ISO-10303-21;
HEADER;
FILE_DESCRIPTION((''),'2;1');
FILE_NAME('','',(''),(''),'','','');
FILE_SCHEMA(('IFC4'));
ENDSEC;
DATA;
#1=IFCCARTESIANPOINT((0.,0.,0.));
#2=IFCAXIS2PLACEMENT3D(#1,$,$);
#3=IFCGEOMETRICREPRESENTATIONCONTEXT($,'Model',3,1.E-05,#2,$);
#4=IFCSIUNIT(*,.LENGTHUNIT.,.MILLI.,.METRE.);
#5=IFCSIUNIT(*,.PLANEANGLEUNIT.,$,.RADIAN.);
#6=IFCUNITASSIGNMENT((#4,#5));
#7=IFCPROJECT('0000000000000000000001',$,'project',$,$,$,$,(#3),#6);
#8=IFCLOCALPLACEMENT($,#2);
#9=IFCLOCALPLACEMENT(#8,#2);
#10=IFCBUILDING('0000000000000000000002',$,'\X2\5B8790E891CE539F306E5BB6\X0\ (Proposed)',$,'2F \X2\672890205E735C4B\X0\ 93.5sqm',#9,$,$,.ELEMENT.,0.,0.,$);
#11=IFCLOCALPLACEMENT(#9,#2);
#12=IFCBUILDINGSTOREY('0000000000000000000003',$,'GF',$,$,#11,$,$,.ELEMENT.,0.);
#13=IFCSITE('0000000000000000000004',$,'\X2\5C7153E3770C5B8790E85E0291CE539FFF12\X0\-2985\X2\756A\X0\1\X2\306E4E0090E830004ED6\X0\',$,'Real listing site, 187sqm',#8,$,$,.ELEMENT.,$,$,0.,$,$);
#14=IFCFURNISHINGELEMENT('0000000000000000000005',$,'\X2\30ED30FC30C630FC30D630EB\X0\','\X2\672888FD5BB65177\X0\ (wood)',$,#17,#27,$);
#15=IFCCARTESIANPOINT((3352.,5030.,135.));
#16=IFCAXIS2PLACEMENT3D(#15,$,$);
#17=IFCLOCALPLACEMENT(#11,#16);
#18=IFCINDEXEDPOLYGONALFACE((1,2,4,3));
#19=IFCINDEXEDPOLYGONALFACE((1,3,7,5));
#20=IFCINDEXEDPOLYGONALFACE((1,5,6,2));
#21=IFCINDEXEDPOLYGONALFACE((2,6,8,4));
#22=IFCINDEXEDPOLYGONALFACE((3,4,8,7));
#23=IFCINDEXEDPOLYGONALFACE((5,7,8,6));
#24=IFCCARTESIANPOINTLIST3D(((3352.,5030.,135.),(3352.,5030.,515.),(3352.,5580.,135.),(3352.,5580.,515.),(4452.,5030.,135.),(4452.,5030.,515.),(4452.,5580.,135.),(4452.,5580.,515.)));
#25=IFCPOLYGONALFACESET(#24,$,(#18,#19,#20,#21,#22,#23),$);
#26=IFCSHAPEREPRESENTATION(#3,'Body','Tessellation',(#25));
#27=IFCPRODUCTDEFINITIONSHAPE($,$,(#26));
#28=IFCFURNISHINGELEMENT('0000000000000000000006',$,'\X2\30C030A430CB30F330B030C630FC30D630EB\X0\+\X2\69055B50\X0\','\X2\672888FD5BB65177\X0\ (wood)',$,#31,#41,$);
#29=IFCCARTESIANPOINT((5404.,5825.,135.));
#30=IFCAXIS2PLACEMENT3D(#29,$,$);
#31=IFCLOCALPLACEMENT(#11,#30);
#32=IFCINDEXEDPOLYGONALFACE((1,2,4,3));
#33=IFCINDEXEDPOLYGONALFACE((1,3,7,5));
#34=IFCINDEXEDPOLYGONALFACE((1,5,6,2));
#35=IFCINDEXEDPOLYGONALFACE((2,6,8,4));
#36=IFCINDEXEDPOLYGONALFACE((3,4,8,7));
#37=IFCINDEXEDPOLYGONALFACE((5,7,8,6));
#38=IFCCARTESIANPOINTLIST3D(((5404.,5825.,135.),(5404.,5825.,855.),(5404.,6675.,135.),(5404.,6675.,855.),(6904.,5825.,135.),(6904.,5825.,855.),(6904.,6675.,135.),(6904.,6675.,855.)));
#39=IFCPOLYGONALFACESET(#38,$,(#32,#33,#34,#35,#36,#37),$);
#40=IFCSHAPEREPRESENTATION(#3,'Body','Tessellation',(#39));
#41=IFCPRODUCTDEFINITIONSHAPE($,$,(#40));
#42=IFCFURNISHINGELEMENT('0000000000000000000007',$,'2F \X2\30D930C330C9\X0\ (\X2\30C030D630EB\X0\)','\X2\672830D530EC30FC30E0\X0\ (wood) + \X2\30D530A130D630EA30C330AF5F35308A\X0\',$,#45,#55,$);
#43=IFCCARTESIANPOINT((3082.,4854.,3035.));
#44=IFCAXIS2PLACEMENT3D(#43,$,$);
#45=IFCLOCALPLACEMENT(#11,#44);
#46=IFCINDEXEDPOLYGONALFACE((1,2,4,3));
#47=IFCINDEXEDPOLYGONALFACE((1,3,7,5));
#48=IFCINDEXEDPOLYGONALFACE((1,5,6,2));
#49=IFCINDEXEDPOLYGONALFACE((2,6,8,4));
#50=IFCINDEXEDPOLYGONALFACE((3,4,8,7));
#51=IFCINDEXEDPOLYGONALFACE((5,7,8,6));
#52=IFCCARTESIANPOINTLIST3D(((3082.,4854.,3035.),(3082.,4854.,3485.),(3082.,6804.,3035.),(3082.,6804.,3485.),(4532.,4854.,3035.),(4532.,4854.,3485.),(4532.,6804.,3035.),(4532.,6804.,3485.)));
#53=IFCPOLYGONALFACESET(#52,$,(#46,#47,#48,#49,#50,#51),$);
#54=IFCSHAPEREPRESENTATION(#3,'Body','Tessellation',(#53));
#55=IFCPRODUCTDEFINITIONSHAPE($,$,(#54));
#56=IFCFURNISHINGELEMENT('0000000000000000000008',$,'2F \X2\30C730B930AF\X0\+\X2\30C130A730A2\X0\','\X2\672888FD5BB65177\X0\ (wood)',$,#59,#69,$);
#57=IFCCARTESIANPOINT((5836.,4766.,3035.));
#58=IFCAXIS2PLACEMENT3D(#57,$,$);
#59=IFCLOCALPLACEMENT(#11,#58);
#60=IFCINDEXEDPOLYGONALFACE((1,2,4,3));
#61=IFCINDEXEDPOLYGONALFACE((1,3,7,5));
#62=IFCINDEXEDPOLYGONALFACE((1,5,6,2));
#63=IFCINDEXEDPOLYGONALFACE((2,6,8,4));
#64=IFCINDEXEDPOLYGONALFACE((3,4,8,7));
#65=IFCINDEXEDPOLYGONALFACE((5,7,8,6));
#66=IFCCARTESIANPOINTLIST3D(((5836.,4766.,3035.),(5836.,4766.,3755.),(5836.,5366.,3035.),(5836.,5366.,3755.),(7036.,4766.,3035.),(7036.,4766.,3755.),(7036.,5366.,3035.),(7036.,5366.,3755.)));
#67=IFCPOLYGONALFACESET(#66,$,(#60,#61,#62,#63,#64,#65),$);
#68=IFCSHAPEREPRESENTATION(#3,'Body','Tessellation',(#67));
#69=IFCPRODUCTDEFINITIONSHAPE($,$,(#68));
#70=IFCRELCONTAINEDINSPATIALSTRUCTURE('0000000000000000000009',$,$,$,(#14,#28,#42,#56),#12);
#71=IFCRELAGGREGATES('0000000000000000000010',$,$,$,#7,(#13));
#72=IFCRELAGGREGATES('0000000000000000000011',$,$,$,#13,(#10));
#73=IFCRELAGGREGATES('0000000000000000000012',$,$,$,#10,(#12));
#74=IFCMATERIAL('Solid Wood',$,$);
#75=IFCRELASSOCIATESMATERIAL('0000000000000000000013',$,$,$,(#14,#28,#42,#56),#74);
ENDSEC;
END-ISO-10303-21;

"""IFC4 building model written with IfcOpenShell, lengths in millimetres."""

from ifc_helpers import new_model, si_unit, frame, frame_2d, origin, place, context, project, spatial, rectangle, extrude, material, element, save


model = new_model("IFC4")

# Units and contexts
model_context = context("Model", 3, precision=1e-05, world=origin())
ifc_project = project(units=[si_unit("LENGTHUNIT", "METRE", prefix="MILLI"), si_unit("PLANEANGLEUNIT", "RADIAN")], contexts=[model_context])

# Site, building, storey
site_placement = place(None, origin())
site = spatial("IfcSite", under=ifc_project, at=site_placement, Name="山口県宇部市野原２-2985番1の一部　他", ObjectType="Real listing site, 187sqm", CompositionType="ELEMENT", RefElevation=0.0)
building_placement = place(site_placement, origin())
building = spatial("IfcBuilding", under=site, at=building_placement, Name="宇部野原の家 (Proposed)", ObjectType="2F 木造平屋 93.5sqm", CompositionType="ELEMENT", ElevationOfRefHeight=0.0, ElevationOfTerrain=0.0)
storey_placement = place(building_placement, origin())
storey = spatial("IfcBuildingStorey", under=building, at=storey_placement, Name="GF", CompositionType="ELEMENT", Elevation=0.0)

# Shared definitions
ifc_material_1 = material(Name="Solid Wood")

# Furnishing elements
furnishing_1_placement = place(storey_placement, frame((3352.0, 5030.0, 135.0)))
element("IfcFurnishingElement", 1, at=furnishing_1_placement, inside=storey, material=ifc_material_1, Name="ローテーブル", Description="木製家具 (wood)", context=model_context, shape_type="SweptSolid", body=[
    extrude(rectangle(XDim=1100.0, YDim=550.0, at=frame_2d((550.0, 275.0))), frame((3352.0, 5030.0, 135.0)), (0.0, 0.0, 1.0), 380.0),
])
furnishing_2_placement = place(storey_placement, frame((5404.0, 5825.0, 135.0)))
element("IfcFurnishingElement", 2, at=furnishing_2_placement, inside=storey, material=ifc_material_1, Name="ダイニングテーブル+椅子", Description="木製家具 (wood)", context=model_context, shape_type="SweptSolid", body=[
    extrude(rectangle(XDim=1500.0, YDim=850.0, at=frame_2d((750.0, 425.0))), frame((5404.0, 5825.0, 135.0)), (0.0, 0.0, 1.0), 720.0),
])
furnishing_3_placement = place(storey_placement, frame((3082.0, 4854.0, 3035.0)))
element("IfcFurnishingElement", 3, at=furnishing_3_placement, inside=storey, material=ifc_material_1, Name="2F ベッド (ダブル)", Description="木フレーム (wood) + ファブリック張り", context=model_context, shape_type="SweptSolid", body=[
    extrude(rectangle(XDim=1450.0, YDim=1950.0, at=frame_2d((725.0, 975.0))), frame((3082.0, 4854.0, 3035.0)), (0.0, 0.0, 1.0), 450.0),
])
furnishing_4_placement = place(storey_placement, frame((5836.0, 4766.0, 3035.0)))
element("IfcFurnishingElement", 4, at=furnishing_4_placement, inside=storey, material=ifc_material_1, Name="2F デスク+チェア", Description="木製家具 (wood)", context=model_context, shape_type="SweptSolid", body=[
    extrude(rectangle(XDim=1200.0, YDim=600.0, at=frame_2d((600.0, 300.0))), frame((5836.0, 4766.0, 3035.0)), (0.0, 0.0, 1.0), 720.0),
])

save(model, "model.ifc")
